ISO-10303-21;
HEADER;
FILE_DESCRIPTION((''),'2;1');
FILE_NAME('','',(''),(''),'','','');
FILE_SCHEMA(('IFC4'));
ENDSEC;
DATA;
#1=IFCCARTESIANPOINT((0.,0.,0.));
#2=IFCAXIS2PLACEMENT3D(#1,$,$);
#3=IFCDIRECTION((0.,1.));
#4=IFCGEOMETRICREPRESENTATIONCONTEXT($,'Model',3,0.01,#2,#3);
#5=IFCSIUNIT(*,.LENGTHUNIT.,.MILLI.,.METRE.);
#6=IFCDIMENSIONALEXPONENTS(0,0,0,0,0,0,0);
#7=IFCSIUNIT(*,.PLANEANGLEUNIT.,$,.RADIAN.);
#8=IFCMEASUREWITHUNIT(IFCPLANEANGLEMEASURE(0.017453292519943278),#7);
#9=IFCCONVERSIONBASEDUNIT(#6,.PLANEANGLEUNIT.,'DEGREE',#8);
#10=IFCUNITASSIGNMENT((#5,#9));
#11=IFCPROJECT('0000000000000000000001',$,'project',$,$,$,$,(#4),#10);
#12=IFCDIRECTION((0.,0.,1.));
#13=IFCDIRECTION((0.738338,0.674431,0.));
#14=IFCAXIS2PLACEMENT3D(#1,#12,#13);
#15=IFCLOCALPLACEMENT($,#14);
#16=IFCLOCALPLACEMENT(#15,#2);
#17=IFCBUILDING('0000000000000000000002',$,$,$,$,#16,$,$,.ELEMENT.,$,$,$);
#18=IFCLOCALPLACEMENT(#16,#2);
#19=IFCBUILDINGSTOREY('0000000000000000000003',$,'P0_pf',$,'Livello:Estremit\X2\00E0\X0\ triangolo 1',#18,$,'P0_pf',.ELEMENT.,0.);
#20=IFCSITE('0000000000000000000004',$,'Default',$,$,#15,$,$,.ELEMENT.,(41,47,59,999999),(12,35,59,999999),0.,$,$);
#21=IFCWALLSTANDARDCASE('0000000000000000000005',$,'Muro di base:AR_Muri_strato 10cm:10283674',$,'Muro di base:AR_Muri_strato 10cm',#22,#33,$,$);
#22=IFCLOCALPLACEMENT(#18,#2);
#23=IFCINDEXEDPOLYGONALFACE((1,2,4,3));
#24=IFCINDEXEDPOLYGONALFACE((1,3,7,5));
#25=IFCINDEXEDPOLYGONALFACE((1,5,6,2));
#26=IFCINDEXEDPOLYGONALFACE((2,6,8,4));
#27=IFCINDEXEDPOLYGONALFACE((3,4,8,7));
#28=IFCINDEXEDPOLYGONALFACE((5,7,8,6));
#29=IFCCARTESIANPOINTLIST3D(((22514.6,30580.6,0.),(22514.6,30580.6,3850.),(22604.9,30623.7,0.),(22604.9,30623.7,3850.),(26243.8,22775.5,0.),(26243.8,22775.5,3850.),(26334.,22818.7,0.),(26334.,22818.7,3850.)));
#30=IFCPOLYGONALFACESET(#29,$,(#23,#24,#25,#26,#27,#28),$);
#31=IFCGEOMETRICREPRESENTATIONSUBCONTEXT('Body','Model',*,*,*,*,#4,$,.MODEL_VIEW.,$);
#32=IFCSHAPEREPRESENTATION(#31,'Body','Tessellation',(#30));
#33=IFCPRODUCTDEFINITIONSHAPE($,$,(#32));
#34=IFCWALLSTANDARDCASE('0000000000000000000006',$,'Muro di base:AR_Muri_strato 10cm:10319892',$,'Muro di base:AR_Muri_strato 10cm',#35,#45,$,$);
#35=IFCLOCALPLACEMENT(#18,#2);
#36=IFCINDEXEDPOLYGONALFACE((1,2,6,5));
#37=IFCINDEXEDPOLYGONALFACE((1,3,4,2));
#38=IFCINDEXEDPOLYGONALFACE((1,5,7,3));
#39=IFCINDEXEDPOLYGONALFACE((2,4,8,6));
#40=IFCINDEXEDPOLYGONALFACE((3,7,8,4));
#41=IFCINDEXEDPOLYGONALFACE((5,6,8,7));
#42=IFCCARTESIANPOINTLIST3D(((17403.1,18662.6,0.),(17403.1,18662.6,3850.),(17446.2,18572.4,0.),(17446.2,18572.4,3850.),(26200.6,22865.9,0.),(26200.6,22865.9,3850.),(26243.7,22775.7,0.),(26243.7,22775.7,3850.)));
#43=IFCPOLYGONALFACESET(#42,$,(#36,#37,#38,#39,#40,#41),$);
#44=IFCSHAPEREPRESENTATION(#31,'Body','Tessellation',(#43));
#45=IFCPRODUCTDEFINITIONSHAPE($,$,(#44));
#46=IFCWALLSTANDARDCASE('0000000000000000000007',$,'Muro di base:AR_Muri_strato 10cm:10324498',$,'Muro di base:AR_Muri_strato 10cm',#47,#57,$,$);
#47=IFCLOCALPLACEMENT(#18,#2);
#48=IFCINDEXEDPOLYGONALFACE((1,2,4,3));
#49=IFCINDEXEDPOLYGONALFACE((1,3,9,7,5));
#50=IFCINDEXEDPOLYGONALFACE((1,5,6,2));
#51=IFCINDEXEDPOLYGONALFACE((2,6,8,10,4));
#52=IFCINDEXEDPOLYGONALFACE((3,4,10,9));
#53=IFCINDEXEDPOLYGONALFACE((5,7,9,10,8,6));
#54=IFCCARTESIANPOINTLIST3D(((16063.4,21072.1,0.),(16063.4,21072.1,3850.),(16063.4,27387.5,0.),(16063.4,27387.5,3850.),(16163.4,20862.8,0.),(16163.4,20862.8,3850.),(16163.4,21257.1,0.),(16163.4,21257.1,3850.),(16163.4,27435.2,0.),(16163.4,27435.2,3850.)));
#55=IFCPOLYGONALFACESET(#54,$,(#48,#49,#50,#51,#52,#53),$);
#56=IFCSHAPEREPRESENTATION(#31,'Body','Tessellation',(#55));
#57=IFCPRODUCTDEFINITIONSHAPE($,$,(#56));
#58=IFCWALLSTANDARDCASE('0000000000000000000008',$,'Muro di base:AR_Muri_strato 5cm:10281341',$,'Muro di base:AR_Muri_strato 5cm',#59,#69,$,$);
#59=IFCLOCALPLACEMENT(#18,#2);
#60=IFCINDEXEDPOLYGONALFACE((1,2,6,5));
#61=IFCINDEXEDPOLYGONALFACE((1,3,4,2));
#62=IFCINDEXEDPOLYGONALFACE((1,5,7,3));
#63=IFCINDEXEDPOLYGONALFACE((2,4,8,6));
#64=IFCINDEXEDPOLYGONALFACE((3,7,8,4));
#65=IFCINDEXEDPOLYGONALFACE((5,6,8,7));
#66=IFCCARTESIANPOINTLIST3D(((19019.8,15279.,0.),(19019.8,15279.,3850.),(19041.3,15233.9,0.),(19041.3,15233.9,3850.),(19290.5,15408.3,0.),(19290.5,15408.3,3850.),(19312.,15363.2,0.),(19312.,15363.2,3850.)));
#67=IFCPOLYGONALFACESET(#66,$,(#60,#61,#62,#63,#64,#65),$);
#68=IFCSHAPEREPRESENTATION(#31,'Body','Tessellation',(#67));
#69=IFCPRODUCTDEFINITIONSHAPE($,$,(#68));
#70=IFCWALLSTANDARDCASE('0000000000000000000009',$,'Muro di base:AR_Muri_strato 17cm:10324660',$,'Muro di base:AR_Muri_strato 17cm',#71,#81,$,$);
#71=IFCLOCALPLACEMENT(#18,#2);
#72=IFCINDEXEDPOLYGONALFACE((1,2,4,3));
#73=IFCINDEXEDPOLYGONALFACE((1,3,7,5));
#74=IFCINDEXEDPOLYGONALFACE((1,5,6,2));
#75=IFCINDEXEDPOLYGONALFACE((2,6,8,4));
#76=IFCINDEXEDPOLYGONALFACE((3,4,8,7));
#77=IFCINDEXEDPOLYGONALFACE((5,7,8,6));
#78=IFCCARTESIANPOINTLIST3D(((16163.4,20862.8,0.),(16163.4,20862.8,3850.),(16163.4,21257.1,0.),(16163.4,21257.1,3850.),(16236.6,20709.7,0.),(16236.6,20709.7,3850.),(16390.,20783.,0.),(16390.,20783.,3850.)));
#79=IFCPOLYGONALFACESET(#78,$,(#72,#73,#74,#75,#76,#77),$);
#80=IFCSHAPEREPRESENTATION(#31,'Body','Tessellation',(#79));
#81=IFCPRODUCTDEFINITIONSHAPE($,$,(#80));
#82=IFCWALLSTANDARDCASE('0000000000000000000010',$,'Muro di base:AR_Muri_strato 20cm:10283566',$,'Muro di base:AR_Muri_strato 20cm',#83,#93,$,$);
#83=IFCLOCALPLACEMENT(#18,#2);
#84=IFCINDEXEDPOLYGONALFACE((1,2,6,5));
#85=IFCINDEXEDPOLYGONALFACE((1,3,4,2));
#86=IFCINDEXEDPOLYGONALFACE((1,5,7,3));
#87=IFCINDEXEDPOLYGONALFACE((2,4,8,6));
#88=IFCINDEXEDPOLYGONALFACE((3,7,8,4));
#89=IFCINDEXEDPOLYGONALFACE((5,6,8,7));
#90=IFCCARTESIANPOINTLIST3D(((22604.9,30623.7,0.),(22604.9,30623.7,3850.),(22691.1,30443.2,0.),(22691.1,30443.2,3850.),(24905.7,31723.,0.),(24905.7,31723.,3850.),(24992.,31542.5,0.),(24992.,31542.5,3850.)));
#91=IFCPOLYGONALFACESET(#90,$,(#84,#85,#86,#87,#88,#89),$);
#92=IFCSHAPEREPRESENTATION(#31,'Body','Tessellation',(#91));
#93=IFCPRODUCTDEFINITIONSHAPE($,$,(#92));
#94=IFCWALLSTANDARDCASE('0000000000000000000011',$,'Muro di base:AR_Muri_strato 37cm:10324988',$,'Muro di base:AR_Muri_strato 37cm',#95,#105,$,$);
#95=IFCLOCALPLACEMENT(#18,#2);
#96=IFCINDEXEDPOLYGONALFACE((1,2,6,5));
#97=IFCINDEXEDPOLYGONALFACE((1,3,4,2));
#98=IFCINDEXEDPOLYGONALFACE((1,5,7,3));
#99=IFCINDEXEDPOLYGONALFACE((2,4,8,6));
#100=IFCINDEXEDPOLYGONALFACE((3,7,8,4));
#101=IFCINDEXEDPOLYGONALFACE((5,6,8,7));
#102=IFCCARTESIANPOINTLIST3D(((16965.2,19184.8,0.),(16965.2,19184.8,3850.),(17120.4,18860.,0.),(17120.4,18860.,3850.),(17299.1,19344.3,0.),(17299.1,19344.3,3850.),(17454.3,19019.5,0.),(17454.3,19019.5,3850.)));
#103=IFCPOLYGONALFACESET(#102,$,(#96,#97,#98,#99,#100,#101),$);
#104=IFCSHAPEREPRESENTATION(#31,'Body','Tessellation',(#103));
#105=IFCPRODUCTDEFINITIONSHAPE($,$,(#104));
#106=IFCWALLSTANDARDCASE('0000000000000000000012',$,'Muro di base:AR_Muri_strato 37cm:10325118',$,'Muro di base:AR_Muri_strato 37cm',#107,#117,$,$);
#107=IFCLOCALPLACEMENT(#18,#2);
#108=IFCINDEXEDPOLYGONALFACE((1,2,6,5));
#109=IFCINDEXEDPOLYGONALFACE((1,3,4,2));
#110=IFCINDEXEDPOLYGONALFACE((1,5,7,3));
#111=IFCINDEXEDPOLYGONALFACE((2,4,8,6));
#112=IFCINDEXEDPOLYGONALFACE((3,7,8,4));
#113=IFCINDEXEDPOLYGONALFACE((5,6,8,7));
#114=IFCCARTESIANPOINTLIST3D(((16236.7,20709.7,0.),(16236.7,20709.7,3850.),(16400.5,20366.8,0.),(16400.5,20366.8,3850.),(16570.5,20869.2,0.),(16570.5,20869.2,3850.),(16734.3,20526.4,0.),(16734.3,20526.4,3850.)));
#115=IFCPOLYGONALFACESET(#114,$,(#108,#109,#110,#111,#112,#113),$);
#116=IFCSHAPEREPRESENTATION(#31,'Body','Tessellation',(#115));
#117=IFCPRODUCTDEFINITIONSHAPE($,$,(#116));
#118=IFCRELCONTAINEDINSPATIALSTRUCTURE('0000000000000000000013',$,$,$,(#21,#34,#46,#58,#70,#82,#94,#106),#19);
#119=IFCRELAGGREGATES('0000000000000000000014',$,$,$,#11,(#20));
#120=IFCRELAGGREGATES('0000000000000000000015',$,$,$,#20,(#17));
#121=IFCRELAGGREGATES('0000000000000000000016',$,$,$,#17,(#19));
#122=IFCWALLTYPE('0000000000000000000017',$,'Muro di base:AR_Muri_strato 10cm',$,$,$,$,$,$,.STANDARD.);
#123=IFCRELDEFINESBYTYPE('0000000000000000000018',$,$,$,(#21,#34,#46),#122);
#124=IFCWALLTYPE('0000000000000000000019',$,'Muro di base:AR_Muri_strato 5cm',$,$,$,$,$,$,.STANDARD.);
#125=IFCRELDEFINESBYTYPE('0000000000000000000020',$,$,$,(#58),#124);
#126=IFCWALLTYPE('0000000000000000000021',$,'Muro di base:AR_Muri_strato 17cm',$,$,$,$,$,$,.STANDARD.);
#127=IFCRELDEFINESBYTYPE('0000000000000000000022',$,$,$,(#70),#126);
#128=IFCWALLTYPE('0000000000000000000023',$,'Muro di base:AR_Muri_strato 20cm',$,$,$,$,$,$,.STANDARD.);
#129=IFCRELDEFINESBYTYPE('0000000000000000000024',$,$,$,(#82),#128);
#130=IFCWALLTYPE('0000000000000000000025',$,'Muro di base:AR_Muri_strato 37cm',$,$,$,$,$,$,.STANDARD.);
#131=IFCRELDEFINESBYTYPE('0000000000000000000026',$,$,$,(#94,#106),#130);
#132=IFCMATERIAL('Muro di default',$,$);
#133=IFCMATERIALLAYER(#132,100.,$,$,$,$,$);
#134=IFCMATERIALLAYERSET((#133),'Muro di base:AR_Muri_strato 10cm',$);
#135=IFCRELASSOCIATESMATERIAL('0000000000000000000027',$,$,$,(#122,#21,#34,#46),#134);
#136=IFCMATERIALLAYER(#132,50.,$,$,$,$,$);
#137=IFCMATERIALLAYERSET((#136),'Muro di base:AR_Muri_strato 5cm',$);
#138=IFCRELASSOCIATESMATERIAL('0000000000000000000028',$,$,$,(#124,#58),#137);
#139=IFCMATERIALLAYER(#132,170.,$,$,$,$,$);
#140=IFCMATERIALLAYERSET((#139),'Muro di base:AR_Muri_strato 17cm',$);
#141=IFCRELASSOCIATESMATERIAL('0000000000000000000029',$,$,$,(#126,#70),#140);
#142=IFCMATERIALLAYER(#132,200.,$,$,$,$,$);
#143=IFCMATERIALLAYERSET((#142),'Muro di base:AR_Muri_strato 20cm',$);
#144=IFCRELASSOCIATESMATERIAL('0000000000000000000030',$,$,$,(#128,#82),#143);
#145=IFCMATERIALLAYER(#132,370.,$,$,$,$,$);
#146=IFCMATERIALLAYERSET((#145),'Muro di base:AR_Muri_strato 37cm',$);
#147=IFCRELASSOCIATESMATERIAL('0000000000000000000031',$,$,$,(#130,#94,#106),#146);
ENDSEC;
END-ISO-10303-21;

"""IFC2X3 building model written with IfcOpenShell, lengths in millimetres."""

from ifc_helpers import new_model, entity, si_unit, converted_unit, direction, frame, frame_2d, origin, place, context, subcontext, project, spatial, polyline, rectangle, outline, extrude, material, layer, layer_set, layer_usage, type_object, element, save


model = new_model("IFC2X3")

# Units and contexts
model_context = context("Model", 3, precision=0.01, world=origin(), true_north=direction((0.0, 1.0)))
body_context = subcontext(model_context, "Body", "Model", "MODEL_VIEW")
ifc_project = project(units=[si_unit("LENGTHUNIT", "METRE", prefix="MILLI"), converted_unit("PLANEANGLEUNIT", "DEGREE", entity("IfcPlaneAngleMeasure", 0.017453292519943278), si_unit("PLANEANGLEUNIT", "RADIAN"), dimensions=[0, 0, 0, 0, 0, 0, 0])], contexts=[model_context])

# Site, building, storey
site_placement = place(None, frame((0.0, 0.0, 0.0), z_axis=(0.0, 0.0, 1.0), x_axis=(0.738338, 0.674431, 0.0)))
site = spatial("IfcSite", under=ifc_project, at=site_placement, Name="Default", CompositionType="ELEMENT", RefLatitude=(41, 47, 59, 999999), RefLongitude=(12, 35, 59, 999999), RefElevation=0.0)
building_placement = place(site_placement, origin())
building = spatial("IfcBuilding", under=site, at=building_placement, CompositionType="ELEMENT")
storey_placement = place(building_placement, origin())
storey = spatial("IfcBuildingStorey", under=building, at=storey_placement, Name="P0_pf", ObjectType="Livello:Estremità triangolo 1", LongName="P0_pf", CompositionType="ELEMENT", Elevation=0.0)

# Wall
ifc_material_1 = material(Name="Muro di default")
ifc_layer_1 = layer(ifc_material_1, 100.0)
ifc_layer_set_1 = layer_set([ifc_layer_1], Name="Muro di base:AR_Muri_strato 10cm")
wall_type_1 = type_object("IfcWallType", Name="Muro di base:AR_Muri_strato 10cm", PredefinedType="STANDARD", material=ifc_layer_set_1)
ifc_layer_usage_1 = layer_usage(ifc_layer_set_1, "AXIS2", "NEGATIVE", 50.0)
wall_1_placement = place(storey_placement, frame((26288.9, 22797.1, 0.0), z_axis=(0.0, 0.0, 1.0), x_axis=(-0.431105, 0.902302, 0.0)))
element("IfcWallStandardCase", 1, at=wall_1_placement, inside=storey, type_object=wall_type_1, material=ifc_layer_usage_1, Name="Muro di base:AR_Muri_strato 10cm:10283674", ObjectType="Muro di base:AR_Muri_strato 10cm", context=body_context, shape_type="SweptSolid", body=[
    extrude(rectangle(XDim=8650.1, YDim=100.0, at=frame_2d((4325.1, 0.0), x_axis=(-1.0, 0.0))), origin(), (0.0, 0.0, 1.0), 3850.0),
])

# Walls
ifc_layer_usage_2 = layer_usage(ifc_layer_set_1, "AXIS2", "POSITIVE", -50.0)
wall_2_placement = place(storey_placement, frame((26222.2, 22820.8, 0.0), z_axis=(0.0, 0.0, 1.0), x_axis=(-0.902302, -0.431105, 0.0)))
element("IfcWallStandardCase", 2, at=wall_2_placement, inside=storey, type_object=wall_type_1, material=ifc_layer_usage_2, Name="Muro di base:AR_Muri_strato 10cm:10319892", ObjectType="Muro di base:AR_Muri_strato 10cm", context=body_context, shape_type="SweptSolid", body=[
    extrude(rectangle(XDim=9750.0, YDim=100.0, at=frame_2d((4875.0, 0.0), x_axis=(-1.0, 0.0))), origin(), (0.0, 0.0, 1.0), 3850.0),
])
ifc_layer_usage_3 = layer_usage(ifc_layer_set_1, "AXIS2", "NEGATIVE", 50.0)
wall_3_placement = place(storey_placement, frame((16113.4, 20862.8, 0.0), z_axis=(0.0, 0.0, 1.0), x_axis=(0.0, 1.0, 0.0)))
element("IfcWallStandardCase", 3, at=wall_3_placement, inside=storey, type_object=wall_type_1, material=ifc_layer_usage_3, Name="Muro di base:AR_Muri_strato 10cm:10324498", ObjectType="Muro di base:AR_Muri_strato 10cm", context=body_context, shape_type="SweptSolid", body=[
    extrude(outline(polyline([(6572.4, -50.0), (6524.6, 50.0), (209.3, 50.0), (0.0, -50.0), (394.3, -50.0), (6572.4, -50.0)])), origin(), (0.0, 0.0, 1.0), 3850.0),
])
ifc_layer_2 = layer(ifc_material_1, 50.0)
ifc_layer_set_2 = layer_set([ifc_layer_2], Name="Muro di base:AR_Muri_strato 5cm")
ifc_layer_usage_4 = layer_usage(ifc_layer_set_2, "AXIS2", "NEGATIVE", 25.0)
wall_type_2 = type_object("IfcWallType", Name="Muro di base:AR_Muri_strato 5cm", PredefinedType="STANDARD", material=ifc_layer_set_2)
wall_4_placement = place(storey_placement, frame((19301.3, 15385.7, 0.0), z_axis=(0.0, 0.0, 1.0), x_axis=(-0.902304, -0.431101, 0.0)))
element("IfcWallStandardCase", 4, at=wall_4_placement, inside=storey, type_object=wall_type_2, material=ifc_layer_usage_4, Name="Muro di base:AR_Muri_strato 5cm:10281341", ObjectType="Muro di base:AR_Muri_strato 5cm", context=body_context, shape_type="SweptSolid", body=[
    extrude(rectangle(XDim=300.0, YDim=50.0, at=frame_2d((150.0, 0.0), x_axis=(-1.0, 0.0))), origin(), (0.0, 0.0, 1.0), 3850.0),
])
ifc_layer_3 = layer(ifc_material_1, 170.0)
ifc_layer_set_3 = layer_set([ifc_layer_3], Name="Muro di base:AR_Muri_strato 17cm")
ifc_layer_usage_5 = layer_usage(ifc_layer_set_3, "AXIS2", "NEGATIVE", 85.0)
wall_type_3 = type_object("IfcWallType", Name="Muro di base:AR_Muri_strato 17cm", PredefinedType="STANDARD", material=ifc_layer_set_3)
wall_5_placement = place(storey_placement, frame((16313.3, 20746.3, 0.0), z_axis=(0.0, 0.0, 1.0), x_axis=(-0.431102, 0.902303, 0.0)))
element("IfcWallStandardCase", 5, at=wall_5_placement, inside=storey, type_object=wall_type_3, material=ifc_layer_usage_5, Name="Muro di base:AR_Muri_strato 17cm:10324660", ObjectType="Muro di base:AR_Muri_strato 17cm", context=body_context, shape_type="SweptSolid", body=[
    extrude(outline(polyline([(525.5, -85.0), (169.7, 85.0), (0.0, 85.0), (0.0, -85.0), (525.5, -85.0)])), origin(), (0.0, 0.0, 1.0), 3850.0),
])
ifc_layer_4 = layer(ifc_material_1, 200.0)
ifc_layer_set_4 = layer_set([ifc_layer_4], Name="Muro di base:AR_Muri_strato 20cm")
ifc_layer_usage_6 = layer_usage(ifc_layer_set_4, "AXIS2", "NEGATIVE", 100.0)
wall_type_4 = type_object("IfcWallType", Name="Muro di base:AR_Muri_strato 20cm", PredefinedType="STANDARD", material=ifc_layer_set_4)
wall_6_placement = place(storey_placement, frame((24948.9, 31632.8, 0.0), z_axis=(0.0, 0.0, 1.0), x_axis=(-0.902302, -0.431105, 0.0)))
element("IfcWallStandardCase", 6, at=wall_6_placement, inside=storey, type_object=wall_type_4, material=ifc_layer_usage_6, Name="Muro di base:AR_Muri_strato 20cm:10283566", ObjectType="Muro di base:AR_Muri_strato 20cm", context=body_context, shape_type="SweptSolid", body=[
    extrude(rectangle(XDim=2550.0, YDim=200.0, at=frame_2d((1275.0, 0.0), x_axis=(-1.0, 0.0))), origin(), (0.0, 0.0, 1.0), 3850.0),
])

# Walls
ifc_layer_5 = layer(ifc_material_1, 370.0)
ifc_layer_set_5 = layer_set([ifc_layer_5], Name="Muro di base:AR_Muri_strato 37cm")
ifc_layer_usage_7 = layer_usage(ifc_layer_set_5, "AXIS2", "NEGATIVE", 185.0)
wall_type_5 = type_object("IfcWallType", Name="Muro di base:AR_Muri_strato 37cm", PredefinedType="STANDARD", material=ifc_layer_set_5)
wall_7_placement = place(storey_placement, frame((17287.3, 18939.7, 0.0), z_axis=(0.0, 0.0, 1.0), x_axis=(-0.431101, 0.902304, 0.0)))
element("IfcWallStandardCase", 7, at=wall_7_placement, inside=storey, type_object=wall_type_5, material=ifc_layer_usage_7, Name="Muro di base:AR_Muri_strato 37cm:10324988", ObjectType="Muro di base:AR_Muri_strato 37cm", context=body_context, shape_type="SweptSolid", body=[
    extrude(rectangle(XDim=360.0, YDim=370.0, at=frame_2d((180.0, 0.0), x_axis=(-1.0, 0.0))), origin(), (0.0, 0.0, 1.0), 3850.0),
])
ifc_layer_usage_8 = layer_usage(ifc_layer_set_5, "AXIS2", "NEGATIVE", 185.0)
wall_8_placement = place(storey_placement, frame((16567.4, 20446.6, 0.0), z_axis=(0.0, 0.0, 1.0), x_axis=(-0.431111, 0.902299, 0.0)))
element("IfcWallStandardCase", 8, at=wall_8_placement, inside=storey, type_object=wall_type_5, material=ifc_layer_usage_8, Name="Muro di base:AR_Muri_strato 37cm:10325118", ObjectType="Muro di base:AR_Muri_strato 37cm", context=body_context, shape_type="SweptSolid", body=[
    extrude(rectangle(XDim=380.0, YDim=370.0, at=frame_2d((190.0, 0.0), x_axis=(-1.0, 0.0))), origin(), (0.0, 0.0, 1.0), 3850.0),
])

save(model, "model.ifc")
